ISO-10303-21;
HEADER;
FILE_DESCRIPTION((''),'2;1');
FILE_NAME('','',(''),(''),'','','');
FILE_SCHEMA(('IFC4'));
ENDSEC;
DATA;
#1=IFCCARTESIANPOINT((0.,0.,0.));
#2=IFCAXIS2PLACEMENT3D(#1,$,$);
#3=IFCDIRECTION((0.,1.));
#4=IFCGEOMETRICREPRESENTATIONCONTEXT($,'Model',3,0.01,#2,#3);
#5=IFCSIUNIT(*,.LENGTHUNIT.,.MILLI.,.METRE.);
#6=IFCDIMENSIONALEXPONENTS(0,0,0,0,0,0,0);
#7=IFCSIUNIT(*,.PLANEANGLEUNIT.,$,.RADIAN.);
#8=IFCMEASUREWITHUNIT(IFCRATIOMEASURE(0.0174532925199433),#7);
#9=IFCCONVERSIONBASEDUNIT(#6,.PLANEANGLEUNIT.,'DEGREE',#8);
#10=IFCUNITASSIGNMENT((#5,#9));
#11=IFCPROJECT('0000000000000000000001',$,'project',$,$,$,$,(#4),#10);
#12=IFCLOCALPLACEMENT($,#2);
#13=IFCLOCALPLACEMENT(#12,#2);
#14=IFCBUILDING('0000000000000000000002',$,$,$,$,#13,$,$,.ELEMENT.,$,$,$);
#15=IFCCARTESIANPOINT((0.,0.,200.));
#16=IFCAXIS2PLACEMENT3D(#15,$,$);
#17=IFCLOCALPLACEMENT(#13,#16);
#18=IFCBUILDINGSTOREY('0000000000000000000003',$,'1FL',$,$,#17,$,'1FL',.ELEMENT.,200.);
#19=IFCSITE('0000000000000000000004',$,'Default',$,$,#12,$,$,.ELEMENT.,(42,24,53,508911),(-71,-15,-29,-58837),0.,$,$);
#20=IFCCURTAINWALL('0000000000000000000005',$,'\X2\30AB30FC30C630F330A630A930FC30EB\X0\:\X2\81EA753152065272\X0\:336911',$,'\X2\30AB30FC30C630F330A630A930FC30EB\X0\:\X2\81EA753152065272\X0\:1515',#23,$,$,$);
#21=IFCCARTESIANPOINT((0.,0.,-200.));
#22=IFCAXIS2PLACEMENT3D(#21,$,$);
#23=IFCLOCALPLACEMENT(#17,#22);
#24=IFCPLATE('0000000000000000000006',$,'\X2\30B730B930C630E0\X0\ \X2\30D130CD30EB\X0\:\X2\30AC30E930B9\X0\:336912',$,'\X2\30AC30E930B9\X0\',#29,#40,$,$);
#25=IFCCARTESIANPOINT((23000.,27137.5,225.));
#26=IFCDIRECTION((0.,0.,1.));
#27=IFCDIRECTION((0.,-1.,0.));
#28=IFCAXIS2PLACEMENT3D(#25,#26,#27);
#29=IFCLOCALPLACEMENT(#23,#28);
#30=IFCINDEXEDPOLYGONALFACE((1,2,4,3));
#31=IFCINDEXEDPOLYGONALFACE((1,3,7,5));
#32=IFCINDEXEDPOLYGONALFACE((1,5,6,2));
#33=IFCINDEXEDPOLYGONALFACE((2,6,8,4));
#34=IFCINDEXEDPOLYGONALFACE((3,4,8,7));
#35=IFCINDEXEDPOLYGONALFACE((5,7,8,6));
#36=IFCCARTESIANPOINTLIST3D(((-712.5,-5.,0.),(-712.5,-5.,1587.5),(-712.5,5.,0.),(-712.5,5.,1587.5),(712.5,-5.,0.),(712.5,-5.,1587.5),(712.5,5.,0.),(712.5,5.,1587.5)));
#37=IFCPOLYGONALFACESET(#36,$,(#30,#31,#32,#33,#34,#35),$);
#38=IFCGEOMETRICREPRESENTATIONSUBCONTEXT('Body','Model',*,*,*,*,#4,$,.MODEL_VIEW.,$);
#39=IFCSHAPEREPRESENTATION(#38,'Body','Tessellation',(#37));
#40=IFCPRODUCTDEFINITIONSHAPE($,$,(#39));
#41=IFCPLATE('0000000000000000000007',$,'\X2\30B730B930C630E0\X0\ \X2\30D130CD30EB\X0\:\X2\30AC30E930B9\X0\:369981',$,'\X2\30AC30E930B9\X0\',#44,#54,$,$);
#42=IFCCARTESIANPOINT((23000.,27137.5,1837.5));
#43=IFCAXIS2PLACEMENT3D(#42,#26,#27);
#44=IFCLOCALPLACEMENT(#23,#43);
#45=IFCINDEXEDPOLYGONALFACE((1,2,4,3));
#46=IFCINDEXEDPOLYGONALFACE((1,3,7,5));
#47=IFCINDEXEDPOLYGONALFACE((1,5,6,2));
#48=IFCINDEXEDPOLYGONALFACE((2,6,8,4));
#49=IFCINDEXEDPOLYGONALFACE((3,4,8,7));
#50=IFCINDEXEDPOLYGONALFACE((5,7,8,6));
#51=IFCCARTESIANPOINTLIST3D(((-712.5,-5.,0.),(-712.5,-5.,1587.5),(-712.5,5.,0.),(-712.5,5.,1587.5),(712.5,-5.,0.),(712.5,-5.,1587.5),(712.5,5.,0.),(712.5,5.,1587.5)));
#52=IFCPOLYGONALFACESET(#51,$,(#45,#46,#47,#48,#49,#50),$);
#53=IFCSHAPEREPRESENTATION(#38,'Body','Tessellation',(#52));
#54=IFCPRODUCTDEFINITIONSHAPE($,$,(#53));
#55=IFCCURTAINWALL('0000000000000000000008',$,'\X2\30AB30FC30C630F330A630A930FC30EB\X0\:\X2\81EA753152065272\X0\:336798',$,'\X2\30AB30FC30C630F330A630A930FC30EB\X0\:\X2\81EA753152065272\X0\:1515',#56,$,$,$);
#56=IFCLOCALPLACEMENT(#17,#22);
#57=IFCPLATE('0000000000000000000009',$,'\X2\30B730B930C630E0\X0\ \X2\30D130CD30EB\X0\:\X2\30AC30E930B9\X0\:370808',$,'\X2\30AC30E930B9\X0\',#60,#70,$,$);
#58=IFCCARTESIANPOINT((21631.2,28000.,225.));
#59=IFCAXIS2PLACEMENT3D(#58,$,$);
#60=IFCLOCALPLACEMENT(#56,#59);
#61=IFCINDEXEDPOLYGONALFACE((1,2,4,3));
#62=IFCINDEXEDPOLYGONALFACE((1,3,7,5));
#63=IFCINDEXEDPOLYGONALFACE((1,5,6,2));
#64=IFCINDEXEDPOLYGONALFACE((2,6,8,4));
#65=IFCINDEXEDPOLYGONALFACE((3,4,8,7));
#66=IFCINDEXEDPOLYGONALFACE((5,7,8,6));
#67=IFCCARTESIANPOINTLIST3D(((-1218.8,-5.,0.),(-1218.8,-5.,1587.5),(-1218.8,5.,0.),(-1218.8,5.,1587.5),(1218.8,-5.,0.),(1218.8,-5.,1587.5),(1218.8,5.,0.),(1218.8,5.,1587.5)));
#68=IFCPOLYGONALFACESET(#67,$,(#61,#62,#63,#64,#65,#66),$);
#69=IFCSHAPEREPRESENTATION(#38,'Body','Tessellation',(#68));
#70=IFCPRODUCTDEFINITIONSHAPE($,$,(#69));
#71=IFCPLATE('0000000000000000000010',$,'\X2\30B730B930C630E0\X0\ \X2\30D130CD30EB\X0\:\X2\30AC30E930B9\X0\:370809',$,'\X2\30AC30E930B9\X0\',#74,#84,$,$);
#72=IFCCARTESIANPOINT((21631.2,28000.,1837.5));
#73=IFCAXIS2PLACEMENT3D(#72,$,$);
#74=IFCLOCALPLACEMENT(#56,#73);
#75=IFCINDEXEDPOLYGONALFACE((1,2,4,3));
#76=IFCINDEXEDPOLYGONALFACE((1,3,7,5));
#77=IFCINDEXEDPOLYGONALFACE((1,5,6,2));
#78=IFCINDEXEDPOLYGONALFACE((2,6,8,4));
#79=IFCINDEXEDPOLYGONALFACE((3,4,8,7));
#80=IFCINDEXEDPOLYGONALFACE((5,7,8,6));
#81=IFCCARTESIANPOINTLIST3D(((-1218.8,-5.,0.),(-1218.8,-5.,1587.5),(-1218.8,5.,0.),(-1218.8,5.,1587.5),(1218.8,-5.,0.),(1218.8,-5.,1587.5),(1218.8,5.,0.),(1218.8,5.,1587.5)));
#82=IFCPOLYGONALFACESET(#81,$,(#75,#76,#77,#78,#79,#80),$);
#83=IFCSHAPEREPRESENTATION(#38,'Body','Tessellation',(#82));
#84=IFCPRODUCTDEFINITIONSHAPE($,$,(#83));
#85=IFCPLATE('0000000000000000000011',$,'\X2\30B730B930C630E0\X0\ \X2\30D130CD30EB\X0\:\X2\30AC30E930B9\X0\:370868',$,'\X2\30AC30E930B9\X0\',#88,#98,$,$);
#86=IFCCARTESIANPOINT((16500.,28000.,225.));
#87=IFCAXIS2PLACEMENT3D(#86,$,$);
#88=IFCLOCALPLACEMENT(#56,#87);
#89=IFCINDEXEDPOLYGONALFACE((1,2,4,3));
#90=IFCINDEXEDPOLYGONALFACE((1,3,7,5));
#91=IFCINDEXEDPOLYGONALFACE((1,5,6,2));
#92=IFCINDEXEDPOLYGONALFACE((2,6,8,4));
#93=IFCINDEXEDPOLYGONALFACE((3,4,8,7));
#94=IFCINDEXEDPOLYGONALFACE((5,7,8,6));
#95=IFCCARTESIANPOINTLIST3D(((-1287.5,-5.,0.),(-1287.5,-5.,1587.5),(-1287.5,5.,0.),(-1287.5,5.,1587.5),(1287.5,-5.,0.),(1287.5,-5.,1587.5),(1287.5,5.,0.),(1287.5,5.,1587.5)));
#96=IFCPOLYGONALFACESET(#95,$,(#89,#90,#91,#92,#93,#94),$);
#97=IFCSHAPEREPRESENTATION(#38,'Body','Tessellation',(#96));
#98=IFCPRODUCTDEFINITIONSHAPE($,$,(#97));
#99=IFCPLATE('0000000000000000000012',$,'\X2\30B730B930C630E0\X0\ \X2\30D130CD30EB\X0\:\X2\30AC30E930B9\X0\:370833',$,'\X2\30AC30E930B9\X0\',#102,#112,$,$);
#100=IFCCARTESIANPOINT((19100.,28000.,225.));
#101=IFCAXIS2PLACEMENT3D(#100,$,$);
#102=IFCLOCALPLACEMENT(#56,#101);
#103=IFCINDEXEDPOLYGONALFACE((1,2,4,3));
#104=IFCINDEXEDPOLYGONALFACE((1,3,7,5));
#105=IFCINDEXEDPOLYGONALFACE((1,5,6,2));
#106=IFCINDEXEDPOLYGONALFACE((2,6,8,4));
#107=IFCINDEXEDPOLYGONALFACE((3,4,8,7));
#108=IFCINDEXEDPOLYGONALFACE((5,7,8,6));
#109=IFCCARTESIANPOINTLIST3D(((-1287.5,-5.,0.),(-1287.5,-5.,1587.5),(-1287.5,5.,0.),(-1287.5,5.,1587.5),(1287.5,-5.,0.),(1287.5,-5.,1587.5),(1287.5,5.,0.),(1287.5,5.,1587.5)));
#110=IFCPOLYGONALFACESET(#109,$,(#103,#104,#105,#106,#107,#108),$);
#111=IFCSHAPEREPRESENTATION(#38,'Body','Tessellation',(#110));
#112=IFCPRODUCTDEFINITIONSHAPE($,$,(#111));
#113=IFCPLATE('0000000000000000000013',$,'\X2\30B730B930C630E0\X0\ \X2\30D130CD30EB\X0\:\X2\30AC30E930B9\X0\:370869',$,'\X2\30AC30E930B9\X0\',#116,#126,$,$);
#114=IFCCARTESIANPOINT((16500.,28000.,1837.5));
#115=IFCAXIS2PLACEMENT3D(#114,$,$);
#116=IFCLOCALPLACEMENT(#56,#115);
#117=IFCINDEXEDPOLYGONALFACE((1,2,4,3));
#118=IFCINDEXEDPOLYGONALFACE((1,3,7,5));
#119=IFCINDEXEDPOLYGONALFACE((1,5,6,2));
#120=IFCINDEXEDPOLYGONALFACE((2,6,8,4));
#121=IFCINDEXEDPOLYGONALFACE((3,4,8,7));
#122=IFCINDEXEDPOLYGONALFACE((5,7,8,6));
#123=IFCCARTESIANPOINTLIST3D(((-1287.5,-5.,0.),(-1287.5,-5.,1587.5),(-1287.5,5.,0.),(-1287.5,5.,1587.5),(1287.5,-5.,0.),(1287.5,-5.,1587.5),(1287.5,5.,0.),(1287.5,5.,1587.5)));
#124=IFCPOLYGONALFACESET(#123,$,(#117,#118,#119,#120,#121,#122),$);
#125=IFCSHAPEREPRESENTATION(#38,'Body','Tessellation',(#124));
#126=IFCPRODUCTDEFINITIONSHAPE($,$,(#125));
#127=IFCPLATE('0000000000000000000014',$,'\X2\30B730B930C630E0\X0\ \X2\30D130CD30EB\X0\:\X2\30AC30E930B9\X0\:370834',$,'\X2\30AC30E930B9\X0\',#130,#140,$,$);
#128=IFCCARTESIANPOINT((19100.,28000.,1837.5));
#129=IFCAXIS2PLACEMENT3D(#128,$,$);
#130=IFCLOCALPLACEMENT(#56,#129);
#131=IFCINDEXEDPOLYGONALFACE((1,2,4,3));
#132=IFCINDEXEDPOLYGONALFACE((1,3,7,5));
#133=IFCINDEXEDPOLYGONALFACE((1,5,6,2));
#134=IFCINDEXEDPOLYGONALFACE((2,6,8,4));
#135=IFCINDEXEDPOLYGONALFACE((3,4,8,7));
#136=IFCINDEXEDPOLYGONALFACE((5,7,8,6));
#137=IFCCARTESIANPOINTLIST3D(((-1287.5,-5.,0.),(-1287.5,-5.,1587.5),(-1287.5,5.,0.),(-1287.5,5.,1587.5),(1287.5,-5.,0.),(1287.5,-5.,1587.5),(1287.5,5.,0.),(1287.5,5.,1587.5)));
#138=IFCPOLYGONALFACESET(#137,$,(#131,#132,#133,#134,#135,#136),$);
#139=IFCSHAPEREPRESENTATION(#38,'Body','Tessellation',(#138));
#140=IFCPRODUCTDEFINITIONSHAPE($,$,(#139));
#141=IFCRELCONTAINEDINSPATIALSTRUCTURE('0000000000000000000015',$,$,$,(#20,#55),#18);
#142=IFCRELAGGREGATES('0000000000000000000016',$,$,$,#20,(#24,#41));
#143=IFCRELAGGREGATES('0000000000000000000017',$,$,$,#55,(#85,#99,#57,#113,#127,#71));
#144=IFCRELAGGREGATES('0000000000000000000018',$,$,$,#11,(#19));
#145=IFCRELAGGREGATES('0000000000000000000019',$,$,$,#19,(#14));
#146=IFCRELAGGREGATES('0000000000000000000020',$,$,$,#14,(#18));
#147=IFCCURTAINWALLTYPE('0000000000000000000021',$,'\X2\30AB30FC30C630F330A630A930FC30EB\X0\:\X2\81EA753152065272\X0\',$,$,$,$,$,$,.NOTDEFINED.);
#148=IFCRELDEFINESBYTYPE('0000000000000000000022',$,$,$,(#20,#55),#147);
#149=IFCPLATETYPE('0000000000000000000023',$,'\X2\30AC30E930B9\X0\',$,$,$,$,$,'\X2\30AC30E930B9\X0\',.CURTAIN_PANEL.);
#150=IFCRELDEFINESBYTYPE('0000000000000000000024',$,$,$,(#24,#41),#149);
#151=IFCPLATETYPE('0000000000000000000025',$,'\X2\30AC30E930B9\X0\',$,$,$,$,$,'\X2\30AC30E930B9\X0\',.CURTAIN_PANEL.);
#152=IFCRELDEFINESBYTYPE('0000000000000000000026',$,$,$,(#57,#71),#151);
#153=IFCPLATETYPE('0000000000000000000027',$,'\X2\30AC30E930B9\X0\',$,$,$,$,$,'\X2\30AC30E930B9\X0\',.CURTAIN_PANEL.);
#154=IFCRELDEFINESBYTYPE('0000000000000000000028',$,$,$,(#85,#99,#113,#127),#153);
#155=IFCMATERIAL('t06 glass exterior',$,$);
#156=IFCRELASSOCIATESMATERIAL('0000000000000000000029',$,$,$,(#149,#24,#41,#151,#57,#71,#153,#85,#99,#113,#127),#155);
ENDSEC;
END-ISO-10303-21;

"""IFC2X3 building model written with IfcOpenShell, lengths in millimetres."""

from ifc_helpers import new_model, entity, si_unit, converted_unit, direction, frame, frame_2d, origin, origin_2d_with_axis, place, context, subcontext, project, spatial, rectangle, extrude, source, transform, mapped, material, type_object, type_shapes, element, aggregate, save


model = new_model("IFC2X3")

# Units and contexts
model_context = context("Model", 3, precision=0.01, world=origin(), true_north=direction((0.0, 1.0)))
body_context = subcontext(model_context, "Body", "Model", "MODEL_VIEW")
ifc_project = project(units=[si_unit("LENGTHUNIT", "METRE", prefix="MILLI"), converted_unit("PLANEANGLEUNIT", "DEGREE", entity("IfcRatioMeasure", 0.0174532925199433), si_unit("PLANEANGLEUNIT", "RADIAN"), dimensions=[0, 0, 0, 0, 0, 0, 0])], contexts=[model_context])

# Site, building, storey
site_placement = place(None, origin())
site = spatial("IfcSite", under=ifc_project, at=site_placement, Name="Default", CompositionType="ELEMENT", RefLatitude=(42, 24, 53, 508911), RefLongitude=(-71, -15, -29, -58837), RefElevation=0.0)
building_placement = place(site_placement, origin())
building = spatial("IfcBuilding", under=site, at=building_placement, CompositionType="ELEMENT")
storey_placement = place(building_placement, frame((0.0, 0.0, 200.0)))
storey = spatial("IfcBuildingStorey", under=building, at=storey_placement, Name="1FL", LongName="1FL", CompositionType="ELEMENT", Elevation=200.0)

# Curtain walls, plates
curtain_wall_type = type_object("IfcCurtainWallType", Name="カーテンウォール:自由分割", PredefinedType="NOTDEFINED")
curtain_wall_1_placement = place(storey_placement, frame((0.0, 0.0, -200.0)))
curtain_wall_1 = element("IfcCurtainWall", 1, at=curtain_wall_1_placement, inside=storey, type_object=curtain_wall_type, Name="カーテンウォール:自由分割:336911", ObjectType="カーテンウォール:自由分割:1515")
ifc_material_1 = material(Name="t06 glass exterior")
plate_type_1 = type_object("IfcPlateType", Name="ガラス", ElementType="ガラス", PredefinedType="CURTAIN_PANEL", material=ifc_material_1)
shared_shape_1 = source(origin(), body_context, "Body", "SweptSolid", [
    extrude(rectangle(XDim=10.0, YDim=1425.0, at=origin_2d_with_axis()), frame((0.0, 0.0, 0.0), z_axis=(0.0, 0.0, 1.0), x_axis=(0.0, 1.0, 0.0)), (0.0, 0.0, 1.0), 1587.5),
])
type_shapes(plate_type_1, [shared_shape_1])
plate_1_placement = place(curtain_wall_1_placement, frame((23000.0, 27137.5, 225.0), z_axis=(0.0, 0.0, 1.0), x_axis=(0.0, -1.0, 0.0)))
plate_1 = element("IfcPlate", 2, at=plate_1_placement, type_object=plate_type_1, material=ifc_material_1, Name="システム パネル:ガラス:336912", ObjectType="ガラス", context=body_context, shape_type="MappedRepresentation", body=[
    mapped(shared_shape_1, transform((0.0, 0.0, 0.0), scale=1.0)),
])
plate_2_placement = place(curtain_wall_1_placement, frame((23000.0, 27137.5, 1837.5), z_axis=(0.0, 0.0, 1.0), x_axis=(0.0, -1.0, 0.0)))
plate_2 = element("IfcPlate", 3, at=plate_2_placement, type_object=plate_type_1, material=ifc_material_1, Name="システム パネル:ガラス:369981", ObjectType="ガラス", context=body_context, shape_type="MappedRepresentation", body=[
    mapped(shared_shape_1, transform((0.0, 0.0, 0.0), scale=1.0)),
])
aggregate(curtain_wall_1, [plate_1, plate_2])
curtain_wall_2_placement = place(storey_placement, frame((0.0, 0.0, -200.0)))
curtain_wall_2 = element("IfcCurtainWall", 4, at=curtain_wall_2_placement, inside=storey, type_object=curtain_wall_type, Name="カーテンウォール:自由分割:336798", ObjectType="カーテンウォール:自由分割:1515")
plate_type_2 = type_object("IfcPlateType", Name="ガラス", ElementType="ガラス", PredefinedType="CURTAIN_PANEL", material=ifc_material_1)
shared_shape_2 = source(origin(), body_context, "Body", "SweptSolid", [
    extrude(rectangle(XDim=10.0, YDim=2437.5, at=frame_2d((0.0, 0.0), x_axis=(1.0, 0.0))), frame((0.0, 0.0, 0.0), z_axis=(0.0, 0.0, 1.0), x_axis=(0.0, 1.0, 0.0)), (0.0, 0.0, 1.0), 1587.5),
])
type_shapes(plate_type_2, [shared_shape_2])
plate_3_placement = place(curtain_wall_2_placement, frame((21631.2, 28000.0, 225.0)))
plate_3 = element("IfcPlate", 5, at=plate_3_placement, type_object=plate_type_2, material=ifc_material_1, Name="システム パネル:ガラス:370808", ObjectType="ガラス", context=body_context, shape_type="MappedRepresentation", body=[
    mapped(shared_shape_2, transform((0.0, 0.0, 0.0), scale=1.0)),
])
plate_4_placement = place(curtain_wall_2_placement, frame((21631.2, 28000.0, 1837.5)))
plate_4 = element("IfcPlate", 6, at=plate_4_placement, type_object=plate_type_2, material=ifc_material_1, Name="システム パネル:ガラス:370809", ObjectType="ガラス", context=body_context, shape_type="MappedRepresentation", body=[
    mapped(shared_shape_2, transform((0.0, 0.0, 0.0), scale=1.0)),
])
plate_type_3 = type_object("IfcPlateType", Name="ガラス", ElementType="ガラス", PredefinedType="CURTAIN_PANEL", material=ifc_material_1)
shared_shape_3 = source(origin(), body_context, "Body", "SweptSolid", [
    extrude(rectangle(XDim=10.0, YDim=2575.0, at=origin_2d_with_axis()), frame((0.0, 0.0, 0.0), z_axis=(0.0, 0.0, 1.0), x_axis=(0.0, 1.0, 0.0)), (0.0, 0.0, 1.0), 1587.5),
])
type_shapes(plate_type_3, [shared_shape_3])
plate_5_placement = place(curtain_wall_2_placement, frame((16500.0, 28000.0, 225.0)))
plate_5 = element("IfcPlate", 7, at=plate_5_placement, type_object=plate_type_3, material=ifc_material_1, Name="システム パネル:ガラス:370868", ObjectType="ガラス", context=body_context, shape_type="MappedRepresentation", body=[
    mapped(shared_shape_3, transform((0.0, 0.0, 0.0), scale=1.0)),
])
plate_6_placement = place(curtain_wall_2_placement, frame((19100.0, 28000.0, 225.0)))
plate_6 = element("IfcPlate", 8, at=plate_6_placement, type_object=plate_type_3, material=ifc_material_1, Name="システム パネル:ガラス:370833", ObjectType="ガラス", context=body_context, shape_type="MappedRepresentation", body=[
    mapped(shared_shape_3, transform((0.0, 0.0, 0.0), scale=1.0)),
])
plate_7_placement = place(curtain_wall_2_placement, frame((16500.0, 28000.0, 1837.5)))
plate_7 = element("IfcPlate", 9, at=plate_7_placement, type_object=plate_type_3, material=ifc_material_1, Name="システム パネル:ガラス:370869", ObjectType="ガラス", context=body_context, shape_type="MappedRepresentation", body=[
    mapped(shared_shape_3, transform((0.0, 0.0, 0.0), scale=1.0)),
])
plate_8_placement = place(curtain_wall_2_placement, frame((19100.0, 28000.0, 1837.5)))
plate_8 = element("IfcPlate", 10, at=plate_8_placement, type_object=plate_type_3, material=ifc_material_1, Name="システム パネル:ガラス:370834", ObjectType="ガラス", context=body_context, shape_type="MappedRepresentation", body=[
    mapped(shared_shape_3, transform((0.0, 0.0, 0.0), scale=1.0)),
])
aggregate(curtain_wall_2, [plate_5, plate_6, plate_3, plate_7, plate_8, plate_4])

save(model, "model.ifc")
